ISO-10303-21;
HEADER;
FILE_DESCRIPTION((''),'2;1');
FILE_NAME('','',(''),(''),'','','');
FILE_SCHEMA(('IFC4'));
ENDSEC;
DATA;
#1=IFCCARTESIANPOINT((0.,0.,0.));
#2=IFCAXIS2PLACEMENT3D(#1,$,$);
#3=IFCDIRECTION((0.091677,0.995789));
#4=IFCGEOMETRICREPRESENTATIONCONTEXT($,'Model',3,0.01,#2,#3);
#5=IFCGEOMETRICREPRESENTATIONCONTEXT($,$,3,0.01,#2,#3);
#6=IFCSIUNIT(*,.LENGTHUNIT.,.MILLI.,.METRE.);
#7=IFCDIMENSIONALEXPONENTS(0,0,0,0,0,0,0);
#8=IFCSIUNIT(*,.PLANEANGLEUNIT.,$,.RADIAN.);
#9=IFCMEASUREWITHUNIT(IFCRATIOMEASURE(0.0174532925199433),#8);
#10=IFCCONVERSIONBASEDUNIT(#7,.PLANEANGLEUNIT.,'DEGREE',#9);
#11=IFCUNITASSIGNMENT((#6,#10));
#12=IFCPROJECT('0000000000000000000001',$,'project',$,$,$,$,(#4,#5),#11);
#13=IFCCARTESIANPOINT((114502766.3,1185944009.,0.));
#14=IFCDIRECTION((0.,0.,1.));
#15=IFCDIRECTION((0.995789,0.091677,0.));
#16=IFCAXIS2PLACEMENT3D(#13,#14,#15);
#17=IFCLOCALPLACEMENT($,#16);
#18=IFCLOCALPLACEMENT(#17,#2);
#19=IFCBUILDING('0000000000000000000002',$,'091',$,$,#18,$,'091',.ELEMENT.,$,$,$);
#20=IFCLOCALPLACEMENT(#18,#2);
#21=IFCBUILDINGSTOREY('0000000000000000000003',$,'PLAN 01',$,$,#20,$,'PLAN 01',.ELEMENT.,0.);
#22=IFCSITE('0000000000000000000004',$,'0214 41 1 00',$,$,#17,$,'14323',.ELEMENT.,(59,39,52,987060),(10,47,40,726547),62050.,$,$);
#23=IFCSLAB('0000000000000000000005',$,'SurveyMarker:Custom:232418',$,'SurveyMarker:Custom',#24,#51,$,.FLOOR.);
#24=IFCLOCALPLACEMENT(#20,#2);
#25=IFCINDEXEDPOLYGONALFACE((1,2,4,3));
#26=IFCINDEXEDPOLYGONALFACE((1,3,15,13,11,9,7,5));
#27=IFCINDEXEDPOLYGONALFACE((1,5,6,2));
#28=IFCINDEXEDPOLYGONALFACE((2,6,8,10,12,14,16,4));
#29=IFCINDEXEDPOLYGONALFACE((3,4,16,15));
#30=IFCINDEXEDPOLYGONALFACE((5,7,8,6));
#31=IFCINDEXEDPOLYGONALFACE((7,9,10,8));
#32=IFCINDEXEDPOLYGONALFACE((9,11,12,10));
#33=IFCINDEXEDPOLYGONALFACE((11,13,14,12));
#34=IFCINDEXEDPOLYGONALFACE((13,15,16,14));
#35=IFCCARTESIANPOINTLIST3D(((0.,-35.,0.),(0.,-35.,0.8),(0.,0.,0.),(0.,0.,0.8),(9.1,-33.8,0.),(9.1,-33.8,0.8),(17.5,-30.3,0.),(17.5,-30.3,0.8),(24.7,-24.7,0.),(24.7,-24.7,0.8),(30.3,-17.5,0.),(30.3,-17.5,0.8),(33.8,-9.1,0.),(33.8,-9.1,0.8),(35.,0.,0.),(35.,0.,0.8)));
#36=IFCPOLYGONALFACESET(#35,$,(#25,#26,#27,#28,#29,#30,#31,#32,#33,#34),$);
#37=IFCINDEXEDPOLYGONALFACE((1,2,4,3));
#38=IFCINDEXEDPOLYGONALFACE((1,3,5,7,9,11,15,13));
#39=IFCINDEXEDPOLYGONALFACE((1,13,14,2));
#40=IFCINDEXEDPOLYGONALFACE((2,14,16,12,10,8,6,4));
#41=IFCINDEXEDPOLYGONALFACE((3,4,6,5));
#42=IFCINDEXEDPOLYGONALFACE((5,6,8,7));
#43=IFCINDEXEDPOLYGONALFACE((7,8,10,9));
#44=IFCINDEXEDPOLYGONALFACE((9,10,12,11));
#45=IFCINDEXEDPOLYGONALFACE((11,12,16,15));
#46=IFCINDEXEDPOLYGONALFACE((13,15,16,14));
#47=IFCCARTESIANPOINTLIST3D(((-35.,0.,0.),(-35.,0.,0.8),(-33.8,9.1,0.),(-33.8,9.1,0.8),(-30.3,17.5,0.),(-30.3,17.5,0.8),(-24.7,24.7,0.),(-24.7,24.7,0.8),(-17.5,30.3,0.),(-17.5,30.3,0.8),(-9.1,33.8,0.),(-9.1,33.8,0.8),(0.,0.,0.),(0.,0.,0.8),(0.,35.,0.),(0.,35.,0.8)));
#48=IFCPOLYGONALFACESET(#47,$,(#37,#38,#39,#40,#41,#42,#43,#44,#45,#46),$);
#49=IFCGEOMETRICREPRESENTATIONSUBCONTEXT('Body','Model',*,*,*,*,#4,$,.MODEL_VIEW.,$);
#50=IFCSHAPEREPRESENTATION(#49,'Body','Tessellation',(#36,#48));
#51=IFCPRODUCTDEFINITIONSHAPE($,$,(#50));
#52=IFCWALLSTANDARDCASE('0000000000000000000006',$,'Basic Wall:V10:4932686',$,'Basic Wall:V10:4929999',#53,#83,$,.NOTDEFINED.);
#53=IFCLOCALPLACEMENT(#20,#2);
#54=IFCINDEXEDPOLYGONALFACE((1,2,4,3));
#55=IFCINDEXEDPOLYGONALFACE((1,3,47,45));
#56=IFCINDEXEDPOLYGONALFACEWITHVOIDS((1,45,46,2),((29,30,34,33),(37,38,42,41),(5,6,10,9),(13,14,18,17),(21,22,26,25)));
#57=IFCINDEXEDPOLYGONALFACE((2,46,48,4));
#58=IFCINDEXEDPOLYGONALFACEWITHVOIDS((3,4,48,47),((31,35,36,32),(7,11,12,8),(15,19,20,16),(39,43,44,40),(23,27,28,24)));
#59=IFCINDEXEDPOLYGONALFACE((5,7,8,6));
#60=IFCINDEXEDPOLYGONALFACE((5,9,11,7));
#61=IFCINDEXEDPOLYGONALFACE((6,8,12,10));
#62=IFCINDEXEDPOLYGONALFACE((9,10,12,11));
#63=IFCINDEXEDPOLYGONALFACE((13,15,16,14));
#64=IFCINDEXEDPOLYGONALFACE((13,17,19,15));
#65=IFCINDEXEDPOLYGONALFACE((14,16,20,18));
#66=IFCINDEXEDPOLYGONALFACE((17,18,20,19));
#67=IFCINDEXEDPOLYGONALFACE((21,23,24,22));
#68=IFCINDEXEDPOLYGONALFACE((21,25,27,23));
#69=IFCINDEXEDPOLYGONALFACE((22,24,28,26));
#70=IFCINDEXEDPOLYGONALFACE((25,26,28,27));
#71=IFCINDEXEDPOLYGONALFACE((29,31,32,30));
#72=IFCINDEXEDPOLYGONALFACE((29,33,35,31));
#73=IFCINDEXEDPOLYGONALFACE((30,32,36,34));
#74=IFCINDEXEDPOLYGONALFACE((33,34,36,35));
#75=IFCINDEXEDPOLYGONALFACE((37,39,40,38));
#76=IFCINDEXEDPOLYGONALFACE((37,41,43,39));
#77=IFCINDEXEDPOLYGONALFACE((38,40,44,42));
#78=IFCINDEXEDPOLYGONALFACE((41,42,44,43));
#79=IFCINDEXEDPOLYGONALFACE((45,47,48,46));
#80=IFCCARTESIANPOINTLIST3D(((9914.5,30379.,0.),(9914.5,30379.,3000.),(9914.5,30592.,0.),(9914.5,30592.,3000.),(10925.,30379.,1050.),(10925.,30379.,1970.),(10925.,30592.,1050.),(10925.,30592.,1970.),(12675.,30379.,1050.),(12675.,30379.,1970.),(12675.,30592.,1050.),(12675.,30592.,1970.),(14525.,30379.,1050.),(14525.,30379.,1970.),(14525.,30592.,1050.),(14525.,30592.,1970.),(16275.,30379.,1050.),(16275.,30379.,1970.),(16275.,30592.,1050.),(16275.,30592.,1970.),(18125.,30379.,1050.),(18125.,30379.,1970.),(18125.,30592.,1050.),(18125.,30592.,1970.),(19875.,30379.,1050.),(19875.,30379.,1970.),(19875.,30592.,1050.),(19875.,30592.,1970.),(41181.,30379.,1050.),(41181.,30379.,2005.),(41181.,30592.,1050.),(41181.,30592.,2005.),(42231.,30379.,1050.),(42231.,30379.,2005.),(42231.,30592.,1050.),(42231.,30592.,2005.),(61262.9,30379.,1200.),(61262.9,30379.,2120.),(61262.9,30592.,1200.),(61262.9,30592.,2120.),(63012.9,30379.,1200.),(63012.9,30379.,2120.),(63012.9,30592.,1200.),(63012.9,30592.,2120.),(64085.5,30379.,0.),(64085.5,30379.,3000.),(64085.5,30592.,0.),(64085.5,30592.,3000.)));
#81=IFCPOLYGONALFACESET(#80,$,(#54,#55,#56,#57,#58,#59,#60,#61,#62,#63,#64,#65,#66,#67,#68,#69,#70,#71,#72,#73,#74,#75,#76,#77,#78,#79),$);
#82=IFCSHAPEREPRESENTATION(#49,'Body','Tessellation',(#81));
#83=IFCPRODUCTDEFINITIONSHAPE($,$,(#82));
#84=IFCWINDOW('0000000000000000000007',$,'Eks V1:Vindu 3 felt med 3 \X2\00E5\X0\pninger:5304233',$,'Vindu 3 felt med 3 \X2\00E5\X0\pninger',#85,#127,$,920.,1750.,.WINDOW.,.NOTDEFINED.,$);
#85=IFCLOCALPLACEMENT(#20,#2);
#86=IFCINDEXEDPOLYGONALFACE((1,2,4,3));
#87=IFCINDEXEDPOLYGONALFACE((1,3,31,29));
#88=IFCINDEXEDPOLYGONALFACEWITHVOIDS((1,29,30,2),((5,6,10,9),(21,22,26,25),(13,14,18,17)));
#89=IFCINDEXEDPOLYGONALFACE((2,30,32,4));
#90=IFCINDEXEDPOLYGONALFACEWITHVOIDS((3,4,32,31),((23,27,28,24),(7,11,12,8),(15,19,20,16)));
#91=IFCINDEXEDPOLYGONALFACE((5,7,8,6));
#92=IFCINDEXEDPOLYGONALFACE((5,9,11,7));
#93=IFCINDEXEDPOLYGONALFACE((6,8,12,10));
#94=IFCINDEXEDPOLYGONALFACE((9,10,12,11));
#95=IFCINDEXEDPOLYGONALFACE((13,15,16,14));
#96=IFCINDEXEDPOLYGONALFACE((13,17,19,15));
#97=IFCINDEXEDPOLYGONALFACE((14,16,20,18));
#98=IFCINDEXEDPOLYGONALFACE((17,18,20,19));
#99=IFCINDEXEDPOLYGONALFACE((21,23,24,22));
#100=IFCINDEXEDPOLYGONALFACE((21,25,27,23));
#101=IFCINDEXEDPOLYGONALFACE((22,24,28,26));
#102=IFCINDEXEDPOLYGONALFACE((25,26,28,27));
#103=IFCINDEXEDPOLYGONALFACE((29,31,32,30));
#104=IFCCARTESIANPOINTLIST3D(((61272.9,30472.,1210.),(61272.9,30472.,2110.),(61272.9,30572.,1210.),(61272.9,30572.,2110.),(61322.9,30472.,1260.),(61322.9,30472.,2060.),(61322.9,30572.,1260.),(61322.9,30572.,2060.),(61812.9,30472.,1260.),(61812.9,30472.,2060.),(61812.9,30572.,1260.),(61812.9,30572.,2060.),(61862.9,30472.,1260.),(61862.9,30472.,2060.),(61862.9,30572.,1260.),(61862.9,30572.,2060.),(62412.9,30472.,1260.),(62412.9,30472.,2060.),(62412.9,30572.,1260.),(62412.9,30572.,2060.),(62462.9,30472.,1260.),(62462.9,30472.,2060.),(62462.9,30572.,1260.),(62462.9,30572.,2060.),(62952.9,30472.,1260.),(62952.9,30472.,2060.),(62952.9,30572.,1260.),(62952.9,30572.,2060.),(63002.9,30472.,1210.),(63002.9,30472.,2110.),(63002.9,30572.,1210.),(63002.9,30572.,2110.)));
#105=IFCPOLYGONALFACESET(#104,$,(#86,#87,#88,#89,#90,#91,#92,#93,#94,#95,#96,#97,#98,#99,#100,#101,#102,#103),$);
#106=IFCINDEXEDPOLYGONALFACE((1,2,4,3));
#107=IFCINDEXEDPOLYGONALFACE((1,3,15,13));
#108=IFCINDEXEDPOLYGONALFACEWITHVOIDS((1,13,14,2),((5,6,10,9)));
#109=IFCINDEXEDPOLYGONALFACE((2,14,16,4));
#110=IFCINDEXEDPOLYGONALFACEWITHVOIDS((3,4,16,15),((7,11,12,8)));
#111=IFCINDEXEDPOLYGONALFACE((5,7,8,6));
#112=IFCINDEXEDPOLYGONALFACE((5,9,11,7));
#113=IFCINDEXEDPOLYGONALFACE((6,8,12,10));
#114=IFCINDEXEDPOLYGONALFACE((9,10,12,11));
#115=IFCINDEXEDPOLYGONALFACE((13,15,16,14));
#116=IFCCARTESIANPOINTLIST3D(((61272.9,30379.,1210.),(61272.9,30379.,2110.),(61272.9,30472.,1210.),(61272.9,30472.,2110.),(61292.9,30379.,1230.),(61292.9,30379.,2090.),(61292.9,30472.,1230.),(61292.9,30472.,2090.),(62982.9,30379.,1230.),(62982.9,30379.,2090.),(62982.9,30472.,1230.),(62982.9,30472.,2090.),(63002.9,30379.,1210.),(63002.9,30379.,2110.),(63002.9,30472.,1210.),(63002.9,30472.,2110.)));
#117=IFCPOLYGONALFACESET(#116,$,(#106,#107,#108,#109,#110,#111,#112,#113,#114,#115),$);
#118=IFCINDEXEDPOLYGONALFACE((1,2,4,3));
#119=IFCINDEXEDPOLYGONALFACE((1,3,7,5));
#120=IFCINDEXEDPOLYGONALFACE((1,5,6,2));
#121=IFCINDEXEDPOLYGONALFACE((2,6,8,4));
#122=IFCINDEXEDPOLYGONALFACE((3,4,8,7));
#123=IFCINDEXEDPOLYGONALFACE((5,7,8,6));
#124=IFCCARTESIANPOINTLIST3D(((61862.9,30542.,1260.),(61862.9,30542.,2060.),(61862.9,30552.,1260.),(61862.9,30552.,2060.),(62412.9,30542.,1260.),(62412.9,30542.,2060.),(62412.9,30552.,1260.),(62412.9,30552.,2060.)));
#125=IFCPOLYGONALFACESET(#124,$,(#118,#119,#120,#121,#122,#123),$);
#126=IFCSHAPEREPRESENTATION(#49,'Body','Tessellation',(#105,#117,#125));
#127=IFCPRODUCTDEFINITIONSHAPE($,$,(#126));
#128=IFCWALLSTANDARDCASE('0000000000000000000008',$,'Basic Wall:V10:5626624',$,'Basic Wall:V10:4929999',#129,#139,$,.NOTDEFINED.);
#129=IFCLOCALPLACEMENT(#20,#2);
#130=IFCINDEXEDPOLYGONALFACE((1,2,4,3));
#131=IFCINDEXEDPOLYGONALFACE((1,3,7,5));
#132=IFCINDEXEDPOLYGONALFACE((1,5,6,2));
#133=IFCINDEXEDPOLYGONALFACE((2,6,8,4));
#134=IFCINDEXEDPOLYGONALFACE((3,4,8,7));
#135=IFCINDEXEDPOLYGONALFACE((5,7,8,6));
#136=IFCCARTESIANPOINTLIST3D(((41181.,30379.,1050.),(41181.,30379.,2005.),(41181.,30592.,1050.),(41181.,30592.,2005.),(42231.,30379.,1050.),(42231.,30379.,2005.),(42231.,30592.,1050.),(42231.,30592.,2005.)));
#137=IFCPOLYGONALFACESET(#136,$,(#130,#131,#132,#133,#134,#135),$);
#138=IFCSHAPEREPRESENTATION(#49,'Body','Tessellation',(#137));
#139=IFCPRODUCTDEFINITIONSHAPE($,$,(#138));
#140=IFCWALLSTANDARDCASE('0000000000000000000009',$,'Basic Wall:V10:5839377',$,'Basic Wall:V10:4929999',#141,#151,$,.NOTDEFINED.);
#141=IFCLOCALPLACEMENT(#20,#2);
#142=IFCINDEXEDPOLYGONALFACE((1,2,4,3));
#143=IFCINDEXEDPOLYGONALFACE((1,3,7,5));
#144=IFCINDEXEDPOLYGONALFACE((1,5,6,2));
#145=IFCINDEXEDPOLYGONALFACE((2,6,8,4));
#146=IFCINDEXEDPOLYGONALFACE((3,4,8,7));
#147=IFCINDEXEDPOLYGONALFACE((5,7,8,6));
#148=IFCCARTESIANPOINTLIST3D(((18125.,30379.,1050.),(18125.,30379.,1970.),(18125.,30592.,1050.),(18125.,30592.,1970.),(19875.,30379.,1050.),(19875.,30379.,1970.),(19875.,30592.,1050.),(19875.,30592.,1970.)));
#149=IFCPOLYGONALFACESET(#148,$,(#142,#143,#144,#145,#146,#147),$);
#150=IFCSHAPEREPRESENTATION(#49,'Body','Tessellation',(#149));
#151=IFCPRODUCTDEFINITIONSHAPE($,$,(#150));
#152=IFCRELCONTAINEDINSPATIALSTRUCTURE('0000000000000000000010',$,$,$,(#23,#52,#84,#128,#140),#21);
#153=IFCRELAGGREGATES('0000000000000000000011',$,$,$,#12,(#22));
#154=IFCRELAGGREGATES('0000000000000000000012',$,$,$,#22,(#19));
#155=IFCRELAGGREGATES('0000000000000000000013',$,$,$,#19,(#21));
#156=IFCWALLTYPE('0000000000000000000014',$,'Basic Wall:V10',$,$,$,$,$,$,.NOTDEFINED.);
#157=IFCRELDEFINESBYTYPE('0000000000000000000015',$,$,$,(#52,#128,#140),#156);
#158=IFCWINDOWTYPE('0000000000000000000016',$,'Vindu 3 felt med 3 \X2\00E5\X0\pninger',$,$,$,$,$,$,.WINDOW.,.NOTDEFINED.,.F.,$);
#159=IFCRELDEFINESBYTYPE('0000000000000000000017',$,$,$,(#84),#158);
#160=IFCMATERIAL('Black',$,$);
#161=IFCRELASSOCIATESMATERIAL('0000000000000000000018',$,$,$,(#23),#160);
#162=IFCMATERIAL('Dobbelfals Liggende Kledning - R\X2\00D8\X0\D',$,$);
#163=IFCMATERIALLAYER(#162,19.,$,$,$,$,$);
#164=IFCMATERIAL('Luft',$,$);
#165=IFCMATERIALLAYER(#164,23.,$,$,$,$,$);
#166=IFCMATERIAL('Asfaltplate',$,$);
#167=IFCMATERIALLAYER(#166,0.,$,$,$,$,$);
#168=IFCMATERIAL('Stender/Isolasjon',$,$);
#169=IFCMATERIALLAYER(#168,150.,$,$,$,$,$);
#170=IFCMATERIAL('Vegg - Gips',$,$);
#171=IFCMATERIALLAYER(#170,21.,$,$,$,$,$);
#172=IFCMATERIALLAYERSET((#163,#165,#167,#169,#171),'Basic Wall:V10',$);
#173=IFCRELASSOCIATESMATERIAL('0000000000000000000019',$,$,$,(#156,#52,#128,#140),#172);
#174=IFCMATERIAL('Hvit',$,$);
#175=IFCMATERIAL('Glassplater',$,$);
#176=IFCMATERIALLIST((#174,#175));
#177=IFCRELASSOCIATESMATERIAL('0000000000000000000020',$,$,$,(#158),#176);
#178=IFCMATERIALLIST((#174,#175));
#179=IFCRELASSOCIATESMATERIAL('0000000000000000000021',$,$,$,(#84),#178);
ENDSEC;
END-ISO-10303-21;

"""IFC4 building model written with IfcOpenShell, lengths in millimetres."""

from ifc_helpers import new_model, entity, si_unit, converted_unit, direction, frame, frame_2d, origin, origin_2d_with_axis, place, context, subcontext, project, spatial, polyline, circle_curve, parameter, trimmed, segment, composite_curve, rectangle, outline, extrude, source, transform, mapped, material, material_list, layer, layer_set, layer_usage, type_object, type_shapes, element, fill, save


model = new_model("IFC4")

# Units and contexts
model_context = context("Model", 3, precision=0.01, world=origin(), true_north=direction((0.091677, 0.995789)))
context_of_model = context(None, 3, precision=0.01, world=origin(), true_north=direction((0.091677, 0.995789)))
body_context = subcontext(model_context, "Body", "Model", "MODEL_VIEW")
ifc_project = project(units=[si_unit("LENGTHUNIT", "METRE", prefix="MILLI"), converted_unit("PLANEANGLEUNIT", "DEGREE", entity("IfcRatioMeasure", 0.0174532925199433), si_unit("PLANEANGLEUNIT", "RADIAN"), dimensions=[0, 0, 0, 0, 0, 0, 0])], contexts=[model_context, context_of_model])

# Site, building, storey
site_placement = place(None, frame((114502766.3, 1185944009.0, 0.0), z_axis=(0.0, 0.0, 1.0), x_axis=(0.995789, 0.091677, 0.0)))
site = spatial("IfcSite", under=ifc_project, at=site_placement, Name="0214 41 1 00", LongName="14323", CompositionType="ELEMENT", RefLatitude=(59, 39, 52, 987060), RefLongitude=(10, 47, 40, 726547), RefElevation=62050.0)
building_placement = place(site_placement, origin())
building = spatial("IfcBuilding", under=site, at=building_placement, Name="091", LongName="091", CompositionType="ELEMENT")
storey_placement = place(building_placement, origin())
storey = spatial("IfcBuildingStorey", under=building, at=storey_placement, Name="PLAN 01", LongName="PLAN 01", CompositionType="ELEMENT", Elevation=0.0)

# Slab
ifc_material_1 = material(Name="Black")
slab_placement = place(storey_placement, origin())
element("IfcSlab", 1, at=slab_placement, inside=storey, material=ifc_material_1, Name="SurveyMarker:Custom:232418", ObjectType="SurveyMarker:Custom", PredefinedType="FLOOR", context=body_context, shape_type="SweptSolid", body=[
    extrude(outline(composite_curve([segment(polyline([(-11.7, -11.7), (23.3, -11.7)]), True, "CONTINUOUS"), segment(trimmed(circle_curve(frame_2d((-11.7, -11.7), x_axis=(0.0, 1.0)), 35.0), [parameter(270.0)], [parameter(360.0)], True, "PARAMETER"), True, "CONTINUOUS"), segment(polyline([(-11.7, 23.3), (-11.7, -11.7)]), True, "CONTINUOUS")], self_intersect=False)), frame((11.7, -11.7, 0.0), z_axis=(0.0, 0.0, 1.0), x_axis=(0.0, -1.0, 0.0)), (0.0, 0.0, 1.0), 0.8),
    extrude(outline(composite_curve([segment(polyline([(-11.7, -11.7), (23.3, -11.7)]), True, "CONTINUOUS"), segment(trimmed(circle_curve(frame_2d((-11.7, -11.7), x_axis=(0.0, 1.0)), 35.0), [parameter(270.0)], [parameter(360.0)], True, "PARAMETER"), True, "CONTINUOUS"), segment(polyline([(-11.7, 23.3), (-11.7, -11.7)]), True, "CONTINUOUS")], self_intersect=False)), frame((-11.7, 11.7, 0.0), z_axis=(0.0, 0.0, 1.0), x_axis=(0.0, 1.0, 0.0)), (0.0, 0.0, 1.0), 0.8),
])

# Wall, openings, window
ifc_material_2 = material(Name="Dobbelfals Liggende Kledning - RØD")
ifc_layer_1 = layer(ifc_material_2, 19.0)
ifc_material_3 = material(Name="Luft")
ifc_layer_2 = layer(ifc_material_3, 23.0)
ifc_material_4 = material(Name="Asfaltplate")
ifc_layer_3 = layer(ifc_material_4, 0.0)
ifc_material_5 = material(Name="Stender/Isolasjon")
ifc_layer_4 = layer(ifc_material_5, 150.0)
ifc_material_6 = material(Name="Vegg - Gips")
ifc_layer_5 = layer(ifc_material_6, 21.0)
ifc_layer_set = layer_set([ifc_layer_1, ifc_layer_2, ifc_layer_3, ifc_layer_4, ifc_layer_5], Name="Basic Wall:V10")
ifc_layer_usage_1 = layer_usage(ifc_layer_set, "AXIS2", "NEGATIVE", 106.5)
wall_type = type_object("IfcWallType", Name="Basic Wall:V10", PredefinedType="NOTDEFINED", material=ifc_layer_set)
wall_1_placement = place(storey_placement, frame((9914.5, 30485.5, 0.0)))
wall_1 = element("IfcWallStandardCase", 2, at=wall_1_placement, inside=storey, type_object=wall_type, material=ifc_layer_usage_1, Name="Basic Wall:V10:4932686", ObjectType="Basic Wall:V10:4929999", PredefinedType="NOTDEFINED", context=body_context, shape_type="SweptSolid", body=[
    extrude(rectangle(XDim=54171.0, YDim=213.0, at=frame_2d((27085.5, 0.0), x_axis=(-1.0, 0.0))), origin(), (0.0, 0.0, 1.0), 3000.0),
])
opening_1_placement = place(wall_1_placement, frame((51348.4, -106.5, 1200.0)))
opening_1 = element("IfcOpeningElement", 3, at=opening_1_placement, cuts=wall_1, ObjectType="Opening", PredefinedType="OPENING", context=body_context, shape_type="SweptSolid", body=[
    extrude(rectangle(XDim=920.0, YDim=1750.0, at=frame_2d((460.0, 875.0), x_axis=(1.0, 0.0))), frame((0.0, 0.0, 0.0), z_axis=(0.0, 1.0, 0.0), x_axis=(0.0, 0.0, 1.0)), (0.0, 0.0, 1.0), 213.0),
])
opening_2_placement = place(wall_1_placement, frame((31266.5, -1630.5, 1050.0)))
element("IfcOpeningElement", 4, at=opening_2_placement, cuts=wall_1, ObjectType="Opening", PredefinedType="OPENING", context=body_context, shape_type="SweptSolid", body=[
    extrude(rectangle(XDim=955.0, YDim=1050.0, at=frame_2d((0.0, 0.0), x_axis=(1.0, 0.0))), frame((525.0, 0.0, 477.5), z_axis=(0.0, 1.0, 0.0), x_axis=(0.0, 0.0, 1.0)), (0.0, 0.0, 1.0), 3048.0),
])
opening_3_placement = place(wall_1_placement, frame((1010.5, -1630.5, 1050.0)))
element("IfcOpeningElement", 5, at=opening_3_placement, cuts=wall_1, ObjectType="Opening", PredefinedType="OPENING", context=body_context, shape_type="SweptSolid", body=[
    extrude(rectangle(XDim=920.0, YDim=1750.0, at=frame_2d((0.0, 0.0), x_axis=(0.0, 1.0))), frame((875.0, 0.0, 460.0), z_axis=(0.0, 1.0, 0.0), x_axis=(-1.0, 0.0, 0.0)), (0.0, 0.0, 1.0), 3048.0),
])
opening_4_placement = place(wall_1_placement, frame((4610.5, -1630.5, 1050.0)))
element("IfcOpeningElement", 6, at=opening_4_placement, cuts=wall_1, ObjectType="Opening", PredefinedType="OPENING", context=body_context, shape_type="SweptSolid", body=[
    extrude(rectangle(XDim=920.0, YDim=1750.0, at=frame_2d((0.0, 0.0), x_axis=(0.0, 1.0))), frame((875.0, 0.0, 460.0), z_axis=(0.0, 1.0, 0.0), x_axis=(-1.0, 0.0, 0.0)), (0.0, 0.0, 1.0), 3048.0),
])
opening_5_placement = place(wall_1_placement, frame((8210.5, -1630.5, 1050.0)))
element("IfcOpeningElement", 7, at=opening_5_placement, cuts=wall_1, ObjectType="Opening", PredefinedType="OPENING", context=body_context, shape_type="SweptSolid", body=[
    extrude(rectangle(XDim=920.0, YDim=1750.0, at=frame_2d((0.0, 0.0), x_axis=(0.0, 1.0))), frame((875.0, 0.0, 460.0), z_axis=(0.0, 1.0, 0.0), x_axis=(-1.0, 0.0, 0.0)), (0.0, 0.0, 1.0), 3048.0),
])
ifc_material_7 = material(Name="Hvit")
ifc_material_8 = material(Name="Glassplater")
ifc_material_list_1 = material_list([ifc_material_7, ifc_material_8])
ifc_material_list_2 = material_list([ifc_material_7, ifc_material_8])
window_type = type_object("IfcWindowType", Name="Vindu 3 felt med 3 åpninger", ParameterTakesPrecedence=False, PartitioningType="NOTDEFINED", PredefinedType="WINDOW", material=ifc_material_list_2)
shared_shape_1 = source(origin(), body_context, "Body", "SweptSolid", [
    extrude(outline(polyline([(-865.0, -450.0), (865.0, -450.0), (865.0, 450.0), (-865.0, 450.0), (-865.0, -450.0)]), holes=[polyline([(-325.0, -400.0), (-815.0, -400.0), (-815.0, 400.0), (-325.0, 400.0), (-325.0, -400.0)]), polyline([(815.0, 400.0), (815.0, -400.0), (325.0, -400.0), (325.0, 400.0), (815.0, 400.0)]), polyline([(-275.0, -400.0), (-275.0, 400.0), (275.0, 400.0), (275.0, -400.0), (-275.0, -400.0)])]), frame((959.8, 153.0, 460.0), z_axis=(0.0, -1.0, 0.0), x_axis=(-1.0, 0.0, 0.0)), (0.0, 0.0, 1.0), 100.0),
    extrude(outline(polyline([(-865.0, -450.0), (865.0, -450.0), (865.0, 450.0), (-865.0, 450.0), (-865.0, -450.0)]), holes=[polyline([(-845.0, -430.0), (-845.0, 430.0), (845.0, 430.0), (845.0, -430.0), (-845.0, -430.0)])]), frame((959.8, 53.0, 460.0), z_axis=(0.0, -1.0, 0.0), x_axis=(1.0, 0.0, 0.0)), (0.0, 0.0, 1.0), 93.0),
    extrude(rectangle(XDim=550.0, YDim=10.0, at=frame_2d((0.0, 0.0), x_axis=(1.0, 0.0))), frame((959.8, 128.0, 60.0), z_axis=(0.0, 0.0, 1.0), x_axis=(-1.0, 0.0, 0.0)), (0.0, 0.0, 1.0), 800.0),
])
type_shapes(window_type, [shared_shape_1])
window_placement = place(opening_1_placement, frame((-84.8, 40.0, 0.0)))
window = element("IfcWindow", 8, at=window_placement, inside=storey, type_object=window_type, material=ifc_material_list_1, Name="Eks V1:Vindu 3 felt med 3 åpninger:5304233", ObjectType="Vindu 3 felt med 3 åpninger", OverallHeight=920.0, OverallWidth=1750.0, PartitioningType="NOTDEFINED", PredefinedType="WINDOW", context=body_context, shape_type="MappedRepresentation", body=[
    mapped(shared_shape_1, transform((0.0, 0.0, 0.0), scale=1.0)),
])
fill(opening_1, window)

# Walls
ifc_layer_usage_2 = layer_usage(ifc_layer_set, "AXIS2", "NEGATIVE", 106.5)
wall_2_placement = place(storey_placement, frame((41181.0, 30485.5, 1050.0)))
element("IfcWallStandardCase", 9, at=wall_2_placement, inside=storey, type_object=wall_type, material=ifc_layer_usage_2, Name="Basic Wall:V10:5626624", ObjectType="Basic Wall:V10:4929999", PredefinedType="NOTDEFINED", context=body_context, shape_type="SweptSolid", body=[
    extrude(rectangle(XDim=1050.0, YDim=213.0, at=origin_2d_with_axis()), frame((525.0, 0.0, 0.0)), (0.0, 0.0, 1.0), 955.0),
])
ifc_layer_usage_3 = layer_usage(ifc_layer_set, "AXIS2", "NEGATIVE", 106.5)
wall_3_placement = place(storey_placement, frame((18125.0, 30485.5, 1050.0)))
element("IfcWallStandardCase", 10, at=wall_3_placement, inside=storey, type_object=wall_type, material=ifc_layer_usage_3, Name="Basic Wall:V10:5839377", ObjectType="Basic Wall:V10:4929999", PredefinedType="NOTDEFINED", context=body_context, shape_type="SweptSolid", body=[
    extrude(rectangle(XDim=1750.0, YDim=213.0, at=frame_2d((0.0, 0.0), x_axis=(1.0, 0.0))), frame((875.0, 0.0, 0.0), z_axis=(0.0, 0.0, 1.0), x_axis=(-1.0, 0.0, 0.0)), (0.0, 0.0, 1.0), 920.0),
])

save(model, "model.ifc")
